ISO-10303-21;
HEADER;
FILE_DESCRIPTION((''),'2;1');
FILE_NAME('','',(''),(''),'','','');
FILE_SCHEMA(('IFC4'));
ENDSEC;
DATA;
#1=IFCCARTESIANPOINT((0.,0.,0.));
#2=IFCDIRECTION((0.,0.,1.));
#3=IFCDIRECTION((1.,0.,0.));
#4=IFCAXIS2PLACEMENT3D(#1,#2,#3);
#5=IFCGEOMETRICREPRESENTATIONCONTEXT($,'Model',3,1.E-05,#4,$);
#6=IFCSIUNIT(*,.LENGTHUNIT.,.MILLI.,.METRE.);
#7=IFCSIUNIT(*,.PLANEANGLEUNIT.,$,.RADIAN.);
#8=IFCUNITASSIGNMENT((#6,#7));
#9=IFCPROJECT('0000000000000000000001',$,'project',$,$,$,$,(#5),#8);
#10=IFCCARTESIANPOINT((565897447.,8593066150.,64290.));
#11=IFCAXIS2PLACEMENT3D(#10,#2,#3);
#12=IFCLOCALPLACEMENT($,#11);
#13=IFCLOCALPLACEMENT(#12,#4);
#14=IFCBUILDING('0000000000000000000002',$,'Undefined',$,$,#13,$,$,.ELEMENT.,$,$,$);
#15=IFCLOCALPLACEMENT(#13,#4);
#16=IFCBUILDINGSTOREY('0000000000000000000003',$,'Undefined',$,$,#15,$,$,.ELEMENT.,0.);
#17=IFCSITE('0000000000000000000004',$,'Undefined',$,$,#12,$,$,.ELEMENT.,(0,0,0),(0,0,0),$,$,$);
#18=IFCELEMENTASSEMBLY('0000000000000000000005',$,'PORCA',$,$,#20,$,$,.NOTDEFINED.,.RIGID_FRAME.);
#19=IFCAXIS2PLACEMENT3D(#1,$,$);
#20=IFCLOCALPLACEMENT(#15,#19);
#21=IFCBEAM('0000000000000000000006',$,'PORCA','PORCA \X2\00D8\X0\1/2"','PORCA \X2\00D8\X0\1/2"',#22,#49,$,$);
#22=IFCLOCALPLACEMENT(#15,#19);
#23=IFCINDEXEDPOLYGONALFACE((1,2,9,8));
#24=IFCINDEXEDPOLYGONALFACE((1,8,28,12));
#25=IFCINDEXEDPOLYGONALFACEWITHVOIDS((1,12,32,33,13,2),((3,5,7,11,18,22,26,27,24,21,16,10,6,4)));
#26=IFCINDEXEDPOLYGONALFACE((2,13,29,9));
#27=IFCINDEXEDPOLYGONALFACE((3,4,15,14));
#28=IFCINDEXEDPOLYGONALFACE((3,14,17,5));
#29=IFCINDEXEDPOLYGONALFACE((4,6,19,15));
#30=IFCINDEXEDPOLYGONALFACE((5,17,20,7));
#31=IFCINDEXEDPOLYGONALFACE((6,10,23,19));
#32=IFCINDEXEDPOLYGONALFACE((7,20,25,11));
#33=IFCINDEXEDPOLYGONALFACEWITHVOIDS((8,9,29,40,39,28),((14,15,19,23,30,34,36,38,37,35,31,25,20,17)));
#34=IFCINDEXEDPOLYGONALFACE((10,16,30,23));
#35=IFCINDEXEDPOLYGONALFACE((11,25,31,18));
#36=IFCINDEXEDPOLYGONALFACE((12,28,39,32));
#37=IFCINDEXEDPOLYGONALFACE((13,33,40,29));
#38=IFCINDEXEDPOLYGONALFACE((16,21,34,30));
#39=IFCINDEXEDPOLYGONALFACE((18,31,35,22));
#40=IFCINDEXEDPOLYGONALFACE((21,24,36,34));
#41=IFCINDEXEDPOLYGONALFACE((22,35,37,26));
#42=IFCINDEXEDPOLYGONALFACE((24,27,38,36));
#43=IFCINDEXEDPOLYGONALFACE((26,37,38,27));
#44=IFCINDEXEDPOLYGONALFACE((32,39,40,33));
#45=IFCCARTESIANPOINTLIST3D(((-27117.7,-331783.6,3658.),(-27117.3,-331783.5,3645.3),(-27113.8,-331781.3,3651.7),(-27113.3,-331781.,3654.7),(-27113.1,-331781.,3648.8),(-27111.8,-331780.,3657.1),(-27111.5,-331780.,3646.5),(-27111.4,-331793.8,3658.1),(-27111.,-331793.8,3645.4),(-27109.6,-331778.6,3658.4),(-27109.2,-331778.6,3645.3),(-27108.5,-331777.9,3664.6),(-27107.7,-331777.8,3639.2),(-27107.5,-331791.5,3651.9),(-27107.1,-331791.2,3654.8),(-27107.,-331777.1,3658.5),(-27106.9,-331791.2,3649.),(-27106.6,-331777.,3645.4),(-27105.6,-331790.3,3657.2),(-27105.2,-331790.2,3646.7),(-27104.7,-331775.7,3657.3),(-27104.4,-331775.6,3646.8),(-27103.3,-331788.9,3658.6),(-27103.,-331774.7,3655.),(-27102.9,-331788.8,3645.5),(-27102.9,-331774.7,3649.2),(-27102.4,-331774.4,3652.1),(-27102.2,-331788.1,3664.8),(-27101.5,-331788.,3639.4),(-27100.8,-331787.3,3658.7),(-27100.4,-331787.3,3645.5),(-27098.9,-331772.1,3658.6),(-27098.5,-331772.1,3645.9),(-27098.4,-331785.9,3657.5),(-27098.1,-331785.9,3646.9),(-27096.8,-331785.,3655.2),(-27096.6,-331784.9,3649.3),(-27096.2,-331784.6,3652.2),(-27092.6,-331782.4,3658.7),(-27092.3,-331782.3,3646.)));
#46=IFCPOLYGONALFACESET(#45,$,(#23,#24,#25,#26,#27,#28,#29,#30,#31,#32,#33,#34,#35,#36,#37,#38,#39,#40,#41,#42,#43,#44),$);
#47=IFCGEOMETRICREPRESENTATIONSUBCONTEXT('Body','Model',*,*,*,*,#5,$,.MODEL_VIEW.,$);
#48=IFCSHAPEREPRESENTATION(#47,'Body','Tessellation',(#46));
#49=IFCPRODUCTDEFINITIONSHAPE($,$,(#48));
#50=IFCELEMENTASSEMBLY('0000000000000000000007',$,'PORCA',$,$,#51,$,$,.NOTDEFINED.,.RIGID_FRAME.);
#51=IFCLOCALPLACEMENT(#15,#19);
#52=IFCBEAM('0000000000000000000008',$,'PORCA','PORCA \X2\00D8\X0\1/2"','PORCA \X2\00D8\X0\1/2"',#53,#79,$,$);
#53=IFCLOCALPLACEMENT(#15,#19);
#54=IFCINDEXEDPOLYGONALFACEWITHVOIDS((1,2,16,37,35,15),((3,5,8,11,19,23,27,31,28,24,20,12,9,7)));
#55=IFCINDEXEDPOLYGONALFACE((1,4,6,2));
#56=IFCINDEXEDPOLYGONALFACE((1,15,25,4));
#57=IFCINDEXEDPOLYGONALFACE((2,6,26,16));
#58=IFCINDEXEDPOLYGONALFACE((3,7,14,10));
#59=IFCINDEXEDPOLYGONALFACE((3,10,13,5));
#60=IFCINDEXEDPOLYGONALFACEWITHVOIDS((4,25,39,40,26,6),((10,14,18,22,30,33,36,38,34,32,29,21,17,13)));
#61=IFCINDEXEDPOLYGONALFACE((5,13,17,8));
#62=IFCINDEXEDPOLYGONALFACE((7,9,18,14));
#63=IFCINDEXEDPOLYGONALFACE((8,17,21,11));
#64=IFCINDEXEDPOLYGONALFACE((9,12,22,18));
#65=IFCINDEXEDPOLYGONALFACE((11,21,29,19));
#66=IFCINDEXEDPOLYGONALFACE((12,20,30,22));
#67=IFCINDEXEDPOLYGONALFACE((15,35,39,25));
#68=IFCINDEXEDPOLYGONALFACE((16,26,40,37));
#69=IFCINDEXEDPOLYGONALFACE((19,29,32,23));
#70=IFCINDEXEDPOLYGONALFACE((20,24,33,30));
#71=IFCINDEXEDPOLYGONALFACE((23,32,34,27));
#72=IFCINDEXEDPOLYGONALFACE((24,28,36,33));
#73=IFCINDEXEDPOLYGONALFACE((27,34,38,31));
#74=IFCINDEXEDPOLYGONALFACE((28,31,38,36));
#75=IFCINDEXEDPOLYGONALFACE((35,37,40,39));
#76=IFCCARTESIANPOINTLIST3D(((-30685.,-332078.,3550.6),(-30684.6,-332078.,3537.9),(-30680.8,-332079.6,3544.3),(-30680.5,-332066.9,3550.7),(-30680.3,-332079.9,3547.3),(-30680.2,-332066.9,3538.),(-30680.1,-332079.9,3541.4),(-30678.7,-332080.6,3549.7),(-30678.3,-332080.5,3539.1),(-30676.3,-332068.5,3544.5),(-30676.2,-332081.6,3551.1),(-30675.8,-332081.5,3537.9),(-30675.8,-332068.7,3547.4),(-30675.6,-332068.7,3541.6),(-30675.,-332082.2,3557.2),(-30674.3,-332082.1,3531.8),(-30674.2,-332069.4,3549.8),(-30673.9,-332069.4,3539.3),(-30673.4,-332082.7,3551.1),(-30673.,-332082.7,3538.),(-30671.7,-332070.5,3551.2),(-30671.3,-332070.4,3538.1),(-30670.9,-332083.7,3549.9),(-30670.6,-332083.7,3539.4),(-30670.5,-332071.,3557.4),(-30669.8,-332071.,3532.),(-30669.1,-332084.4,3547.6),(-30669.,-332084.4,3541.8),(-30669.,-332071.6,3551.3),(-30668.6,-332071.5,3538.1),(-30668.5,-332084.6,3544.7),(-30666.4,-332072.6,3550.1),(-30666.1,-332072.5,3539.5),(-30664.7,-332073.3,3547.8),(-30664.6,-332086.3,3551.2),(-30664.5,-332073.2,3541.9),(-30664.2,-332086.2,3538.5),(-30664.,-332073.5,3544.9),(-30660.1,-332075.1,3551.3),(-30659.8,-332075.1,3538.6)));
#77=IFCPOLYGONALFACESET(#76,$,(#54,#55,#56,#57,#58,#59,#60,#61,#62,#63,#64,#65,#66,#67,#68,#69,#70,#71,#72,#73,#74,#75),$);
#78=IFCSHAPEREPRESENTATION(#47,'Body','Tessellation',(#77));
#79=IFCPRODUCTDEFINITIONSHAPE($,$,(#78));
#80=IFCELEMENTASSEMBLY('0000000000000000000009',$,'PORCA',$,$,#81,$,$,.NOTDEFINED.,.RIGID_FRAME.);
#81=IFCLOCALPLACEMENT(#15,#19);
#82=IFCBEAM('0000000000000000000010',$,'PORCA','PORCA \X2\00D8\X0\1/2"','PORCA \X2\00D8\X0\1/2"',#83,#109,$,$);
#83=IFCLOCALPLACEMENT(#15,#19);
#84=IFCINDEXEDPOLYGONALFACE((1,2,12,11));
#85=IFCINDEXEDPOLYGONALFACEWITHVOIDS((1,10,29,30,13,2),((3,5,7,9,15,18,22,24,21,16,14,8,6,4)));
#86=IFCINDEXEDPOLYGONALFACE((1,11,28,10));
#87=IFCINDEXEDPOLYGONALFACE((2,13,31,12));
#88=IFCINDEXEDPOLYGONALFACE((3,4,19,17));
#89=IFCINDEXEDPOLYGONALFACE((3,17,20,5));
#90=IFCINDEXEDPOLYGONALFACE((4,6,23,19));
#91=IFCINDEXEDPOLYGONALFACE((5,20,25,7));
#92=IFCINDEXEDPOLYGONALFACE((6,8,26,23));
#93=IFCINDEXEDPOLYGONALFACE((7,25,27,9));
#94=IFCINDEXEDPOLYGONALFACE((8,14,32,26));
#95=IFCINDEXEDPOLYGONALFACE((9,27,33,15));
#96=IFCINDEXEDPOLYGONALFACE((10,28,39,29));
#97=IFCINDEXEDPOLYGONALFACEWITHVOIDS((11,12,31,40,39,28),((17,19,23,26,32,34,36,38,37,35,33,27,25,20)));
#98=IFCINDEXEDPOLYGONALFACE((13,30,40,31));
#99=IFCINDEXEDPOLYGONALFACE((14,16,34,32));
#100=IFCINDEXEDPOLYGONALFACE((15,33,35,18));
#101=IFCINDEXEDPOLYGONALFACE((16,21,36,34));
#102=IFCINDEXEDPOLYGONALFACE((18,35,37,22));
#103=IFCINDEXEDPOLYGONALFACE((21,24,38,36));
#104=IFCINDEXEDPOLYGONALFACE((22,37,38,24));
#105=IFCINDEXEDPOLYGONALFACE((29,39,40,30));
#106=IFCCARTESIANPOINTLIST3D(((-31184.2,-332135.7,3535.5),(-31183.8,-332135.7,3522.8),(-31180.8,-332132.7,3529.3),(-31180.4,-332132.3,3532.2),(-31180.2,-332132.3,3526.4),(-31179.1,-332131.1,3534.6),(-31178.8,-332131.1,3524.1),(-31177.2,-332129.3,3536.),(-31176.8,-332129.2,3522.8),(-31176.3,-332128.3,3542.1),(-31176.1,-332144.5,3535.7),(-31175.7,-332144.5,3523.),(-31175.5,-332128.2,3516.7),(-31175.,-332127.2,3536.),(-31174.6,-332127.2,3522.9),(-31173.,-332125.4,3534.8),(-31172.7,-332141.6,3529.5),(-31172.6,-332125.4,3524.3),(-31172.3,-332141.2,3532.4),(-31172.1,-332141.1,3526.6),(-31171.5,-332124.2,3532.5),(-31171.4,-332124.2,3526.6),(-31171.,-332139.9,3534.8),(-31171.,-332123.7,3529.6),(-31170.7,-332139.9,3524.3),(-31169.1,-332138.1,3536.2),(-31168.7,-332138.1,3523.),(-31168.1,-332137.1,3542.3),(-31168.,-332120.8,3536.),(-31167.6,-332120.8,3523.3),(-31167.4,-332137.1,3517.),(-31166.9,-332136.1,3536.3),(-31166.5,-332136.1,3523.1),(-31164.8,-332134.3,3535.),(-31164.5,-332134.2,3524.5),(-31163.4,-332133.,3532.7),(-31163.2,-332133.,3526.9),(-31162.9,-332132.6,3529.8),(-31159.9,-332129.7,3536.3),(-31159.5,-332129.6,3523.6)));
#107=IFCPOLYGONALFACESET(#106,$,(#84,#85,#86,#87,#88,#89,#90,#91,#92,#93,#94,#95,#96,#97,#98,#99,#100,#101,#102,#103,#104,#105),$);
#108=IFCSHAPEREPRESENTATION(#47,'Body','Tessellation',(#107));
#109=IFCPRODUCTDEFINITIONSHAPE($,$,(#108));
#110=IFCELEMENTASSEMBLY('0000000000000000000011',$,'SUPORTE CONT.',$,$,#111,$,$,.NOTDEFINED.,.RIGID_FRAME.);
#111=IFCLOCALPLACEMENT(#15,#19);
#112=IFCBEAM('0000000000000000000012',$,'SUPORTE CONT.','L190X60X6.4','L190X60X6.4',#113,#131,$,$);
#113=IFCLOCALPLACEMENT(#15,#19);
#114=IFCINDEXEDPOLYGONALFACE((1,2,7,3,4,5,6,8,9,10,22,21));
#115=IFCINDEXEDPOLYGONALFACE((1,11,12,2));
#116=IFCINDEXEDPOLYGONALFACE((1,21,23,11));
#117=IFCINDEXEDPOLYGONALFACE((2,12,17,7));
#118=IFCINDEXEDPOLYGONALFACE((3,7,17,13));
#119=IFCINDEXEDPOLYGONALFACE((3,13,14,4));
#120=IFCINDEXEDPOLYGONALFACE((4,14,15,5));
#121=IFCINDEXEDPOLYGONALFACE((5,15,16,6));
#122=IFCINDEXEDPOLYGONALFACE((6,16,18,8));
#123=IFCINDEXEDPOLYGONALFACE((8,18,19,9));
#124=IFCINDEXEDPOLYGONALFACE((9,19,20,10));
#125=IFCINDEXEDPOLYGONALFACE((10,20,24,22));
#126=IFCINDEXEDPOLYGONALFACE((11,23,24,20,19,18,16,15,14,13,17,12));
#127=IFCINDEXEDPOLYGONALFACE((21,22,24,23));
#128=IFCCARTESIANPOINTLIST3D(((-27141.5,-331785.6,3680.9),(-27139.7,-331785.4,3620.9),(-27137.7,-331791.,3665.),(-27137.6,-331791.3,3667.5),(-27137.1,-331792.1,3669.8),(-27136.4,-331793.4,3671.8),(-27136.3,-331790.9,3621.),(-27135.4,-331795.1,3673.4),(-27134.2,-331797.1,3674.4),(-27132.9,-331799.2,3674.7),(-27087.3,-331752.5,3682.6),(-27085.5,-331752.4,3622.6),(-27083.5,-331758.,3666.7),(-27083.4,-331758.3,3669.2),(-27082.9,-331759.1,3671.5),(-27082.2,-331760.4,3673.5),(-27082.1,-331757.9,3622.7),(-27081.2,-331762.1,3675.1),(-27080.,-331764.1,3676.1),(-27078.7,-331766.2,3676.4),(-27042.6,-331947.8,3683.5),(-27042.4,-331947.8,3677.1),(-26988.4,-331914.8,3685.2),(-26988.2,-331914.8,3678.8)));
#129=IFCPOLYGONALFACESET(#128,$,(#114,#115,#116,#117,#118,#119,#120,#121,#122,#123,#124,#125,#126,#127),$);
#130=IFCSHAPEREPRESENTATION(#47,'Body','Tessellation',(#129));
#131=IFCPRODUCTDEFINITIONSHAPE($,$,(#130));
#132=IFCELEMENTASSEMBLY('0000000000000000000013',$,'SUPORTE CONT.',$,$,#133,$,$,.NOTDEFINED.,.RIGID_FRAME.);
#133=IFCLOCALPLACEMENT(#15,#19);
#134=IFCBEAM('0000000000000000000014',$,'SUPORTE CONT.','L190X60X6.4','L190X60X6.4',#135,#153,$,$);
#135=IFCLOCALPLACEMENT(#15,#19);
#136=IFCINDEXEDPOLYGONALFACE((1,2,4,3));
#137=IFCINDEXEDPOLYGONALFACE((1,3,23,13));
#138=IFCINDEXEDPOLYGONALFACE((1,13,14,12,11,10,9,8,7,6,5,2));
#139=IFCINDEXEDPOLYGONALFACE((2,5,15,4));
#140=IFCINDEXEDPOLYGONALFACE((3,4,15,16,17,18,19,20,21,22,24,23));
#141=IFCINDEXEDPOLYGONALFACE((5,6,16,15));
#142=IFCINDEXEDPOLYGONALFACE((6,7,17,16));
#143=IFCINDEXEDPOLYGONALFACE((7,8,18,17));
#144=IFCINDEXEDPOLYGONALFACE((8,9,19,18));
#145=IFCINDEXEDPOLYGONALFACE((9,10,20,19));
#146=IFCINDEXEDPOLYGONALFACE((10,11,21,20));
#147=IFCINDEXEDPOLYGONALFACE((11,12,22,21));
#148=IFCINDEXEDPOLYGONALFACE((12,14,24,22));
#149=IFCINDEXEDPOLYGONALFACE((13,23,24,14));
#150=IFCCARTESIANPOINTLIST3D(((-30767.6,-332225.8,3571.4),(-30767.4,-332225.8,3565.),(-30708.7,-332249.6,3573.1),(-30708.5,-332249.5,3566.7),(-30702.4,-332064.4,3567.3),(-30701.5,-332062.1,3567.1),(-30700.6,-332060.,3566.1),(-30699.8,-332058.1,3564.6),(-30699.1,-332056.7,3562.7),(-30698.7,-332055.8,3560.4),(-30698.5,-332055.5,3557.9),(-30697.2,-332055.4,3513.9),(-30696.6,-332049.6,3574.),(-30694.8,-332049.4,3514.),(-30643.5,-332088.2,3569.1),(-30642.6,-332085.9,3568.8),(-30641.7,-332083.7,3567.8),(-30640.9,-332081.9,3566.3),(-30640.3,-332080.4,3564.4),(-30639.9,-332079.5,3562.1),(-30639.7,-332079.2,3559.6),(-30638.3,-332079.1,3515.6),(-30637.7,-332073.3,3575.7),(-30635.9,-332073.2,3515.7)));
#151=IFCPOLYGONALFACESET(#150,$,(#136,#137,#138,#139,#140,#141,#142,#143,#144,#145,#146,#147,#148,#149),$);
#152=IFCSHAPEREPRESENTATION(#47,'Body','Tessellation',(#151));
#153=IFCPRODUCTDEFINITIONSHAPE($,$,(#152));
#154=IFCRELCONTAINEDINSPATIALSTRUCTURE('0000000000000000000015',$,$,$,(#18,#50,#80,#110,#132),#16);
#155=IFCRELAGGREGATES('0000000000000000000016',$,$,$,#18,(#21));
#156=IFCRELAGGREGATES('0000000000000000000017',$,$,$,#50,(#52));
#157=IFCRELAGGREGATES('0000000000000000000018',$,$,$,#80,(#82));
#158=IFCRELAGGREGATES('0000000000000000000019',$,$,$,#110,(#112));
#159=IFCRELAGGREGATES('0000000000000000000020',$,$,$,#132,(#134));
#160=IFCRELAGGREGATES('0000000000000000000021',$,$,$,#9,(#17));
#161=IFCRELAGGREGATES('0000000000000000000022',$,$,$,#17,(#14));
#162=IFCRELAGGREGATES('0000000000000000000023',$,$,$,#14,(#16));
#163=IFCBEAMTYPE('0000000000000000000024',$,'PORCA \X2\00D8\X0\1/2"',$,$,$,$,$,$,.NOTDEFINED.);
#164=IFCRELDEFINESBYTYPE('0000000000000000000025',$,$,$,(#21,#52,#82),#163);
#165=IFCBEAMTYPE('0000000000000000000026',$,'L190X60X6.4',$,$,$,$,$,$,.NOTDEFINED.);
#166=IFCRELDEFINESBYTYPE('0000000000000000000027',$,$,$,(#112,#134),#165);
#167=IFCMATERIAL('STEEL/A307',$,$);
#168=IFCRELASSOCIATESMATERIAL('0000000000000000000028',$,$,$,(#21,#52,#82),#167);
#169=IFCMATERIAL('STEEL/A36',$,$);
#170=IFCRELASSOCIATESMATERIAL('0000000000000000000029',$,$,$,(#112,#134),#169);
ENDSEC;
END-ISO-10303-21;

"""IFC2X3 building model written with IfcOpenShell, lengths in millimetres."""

from ifc_helpers import new_model, si_unit, frame, origin_with_axes, origin_2d_with_axis, place, context, subcontext, project, spatial, polyline, l_section, outline, extrude, material, type_object, element, aggregate, save


model = new_model("IFC2X3")

# Units and contexts
model_context = context("Model", 3, precision=1e-05, world=origin_with_axes())
body_context = subcontext(model_context, "Body", "Model", "MODEL_VIEW")
ifc_project = project(units=[si_unit("LENGTHUNIT", "METRE", prefix="MILLI"), si_unit("PLANEANGLEUNIT", "RADIAN")], contexts=[model_context])

# Site, building, storey
site_placement = place(None, frame((565897447.0, 8593066150.0, 64290.0), z_axis=(0.0, 0.0, 1.0), x_axis=(1.0, 0.0, 0.0)))
site = spatial("IfcSite", under=ifc_project, at=site_placement, Name="Undefined", CompositionType="ELEMENT", RefLatitude=(0, 0, 0), RefLongitude=(0, 0, 0))
building_placement = place(site_placement, origin_with_axes())
building = spatial("IfcBuilding", under=site, at=building_placement, Name="Undefined", CompositionType="ELEMENT")
storey_placement = place(building_placement, origin_with_axes())
storey = spatial("IfcBuildingStorey", under=building, at=storey_placement, Name="Undefined", CompositionType="ELEMENT", Elevation=0.0)

# Element assemblies, beams
ifc_material_1 = material(Name="STEEL/A36")
ifc_material_2 = material(Name="STEEL/A307")
assembly_1_placement = place(storey_placement, origin_with_axes())
assembly_1 = element("IfcElementAssembly", 1, at=assembly_1_placement, inside=storey, Name="PORCA", AssemblyPlace="NOTDEFINED", PredefinedType="RIGID_FRAME")
beam_type_1 = type_object("IfcBeamType", Name="PORCA Ø1/2\"", PredefinedType="NOTDEFINED")
beam_1_placement = place(assembly_1_placement, frame((-27101.8, -331788.1, 3652.1), z_axis=(-0.853486, -0.520426, -0.026799), x_axis=(-0.520257, 0.853904, -0.013454)))
beam_1 = element("IfcBeam", 2, at=beam_1_placement, type_object=beam_type_1, material=ifc_material_2, Name="PORCA", Description="PORCA Ø1/2\"", ObjectType="PORCA Ø1/2\"", context=body_context, shape_type="SweptSolid", body=[
    extrude(outline(polyline([(-12.7, 0.0), (-6.3, 11.0), (6.3, 11.0), (12.7, 0.0), (6.3, -11.0), (-6.3, -11.0), (-12.7, 0.0)]), holes=[polyline([(5.3, 4.2), (2.9, 6.0), (0.0, 6.7), (-2.9, 6.0), (-5.3, 4.2), (-6.6, 1.5), (-6.6, -1.5), (-5.3, -4.2), (-2.9, -6.0), (0.0, -6.7), (2.9, -6.0), (5.3, -4.2), (6.6, -1.5), (6.6, 1.5), (5.3, 4.2)])]), frame((12.0, 0.0, 0.0), z_axis=(-1.0, 0.0, 0.0), x_axis=(0.0, -1.0, 0.0)), (0.0, 0.0, 1.0), 12.0),
])
aggregate(assembly_1, [beam_1])
assembly_2_placement = place(storey_placement, origin_with_axes())
assembly_2 = element("IfcElementAssembly", 3, at=assembly_2_placement, inside=storey, Name="PORCA", AssemblyPlace="NOTDEFINED", PredefinedType="RIGID_FRAME")
beam_2_placement = place(assembly_2_placement, frame((-30674.6, -332082.1, 3544.5), z_axis=(-0.92709, 0.373879, -0.026799), x_axis=(0.373645, 0.927474, 0.013454)))
beam_2 = element("IfcBeam", 4, at=beam_2_placement, type_object=beam_type_1, material=ifc_material_2, Name="PORCA", Description="PORCA Ø1/2\"", ObjectType="PORCA Ø1/2\"", context=body_context, shape_type="SweptSolid", body=[
    extrude(outline(polyline([(-12.7, 0.0), (-6.3, 11.0), (6.3, 11.0), (12.7, 0.0), (6.3, -11.0), (-6.3, -11.0), (-12.7, 0.0)]), holes=[polyline([(5.3, 4.2), (2.9, 6.0), (0.0, 6.7), (-2.9, 6.0), (-5.3, 4.2), (-6.6, 1.5), (-6.6, -1.5), (-5.3, -4.2), (-2.9, -6.0), (0.0, -6.7), (2.9, -6.0), (5.3, -4.2), (6.6, -1.5), (6.6, 1.5), (5.3, 4.2)])]), frame((12.0, 0.0, 0.0), z_axis=(-1.0, 0.0, 0.0), x_axis=(0.0, -1.0, 0.0)), (0.0, 0.0, 1.0), 12.0),
])
aggregate(assembly_2, [beam_2])
assembly_3_placement = place(storey_placement, origin_with_axes())
assembly_3 = element("IfcElementAssembly", 5, at=assembly_3_placement, inside=storey, Name="PORCA", AssemblyPlace="NOTDEFINED", PredefinedType="RIGID_FRAME")
beam_3_placement = place(assembly_3_placement, frame((-31167.8, -332137.1, 3529.6), z_axis=(-0.736334, -0.676203, -0.02368), x_axis=(-0.675958, 0.736711, -0.018398)))
beam_3 = element("IfcBeam", 6, at=beam_3_placement, type_object=beam_type_1, material=ifc_material_2, Name="PORCA", Description="PORCA Ø1/2\"", ObjectType="PORCA Ø1/2\"", context=body_context, shape_type="SweptSolid", body=[
    extrude(outline(polyline([(-12.7, 0.0), (-6.3, 11.0), (6.3, 11.0), (12.7, 0.0), (6.3, -11.0), (-6.3, -11.0), (-12.7, 0.0)]), holes=[polyline([(5.3, 4.2), (2.9, 6.0), (0.0, 6.7), (-2.9, 6.0), (-5.3, 4.2), (-6.6, 1.5), (-6.6, -1.5), (-5.3, -4.2), (-2.9, -6.0), (0.0, -6.7), (2.9, -6.0), (5.3, -4.2), (6.6, -1.5), (6.6, 1.5), (5.3, 4.2)])]), frame((12.0, 0.0, 0.0), z_axis=(-1.0, 0.0, 0.0), x_axis=(0.0, -1.0, 0.0)), (0.0, 0.0, 1.0), 12.0),
])
aggregate(assembly_3, [beam_3])
assembly_4_placement = place(storey_placement, origin_with_axes())
assembly_4 = element("IfcElementAssembly", 7, at=assembly_4_placement, inside=storey, Name="SUPORTE CONT.", AssemblyPlace="NOTDEFINED", PredefinedType="RIGID_FRAME")
beam_type_2 = type_object("IfcBeamType", Name="L190X60X6.4", PredefinedType="NOTDEFINED")
beam_4_placement = place(assembly_4_placement, frame((-27091.1, -331866.6, 3652.2), z_axis=(0.520257, -0.853904, 0.013454), x_axis=(0.853486, 0.520426, 0.026799)))
beam_4 = element("IfcBeam", 8, at=beam_4_placement, type_object=beam_type_2, material=ifc_material_1, Name="SUPORTE CONT.", Description="L190X60X6.4", ObjectType="L190X60X6.4", context=body_context, shape_type="SweptSolid", body=[
    extrude(l_section(Depth=190.0, Width=60.0, Thickness=6.4, FilletRadius=9.6, at=origin_2d_with_axis()), frame((63.5, 0.0, 0.0), z_axis=(-1.0, 0.0, 0.0), x_axis=(0.0, -1.0, 0.0)), (0.0, 0.0, 1.0), 63.5),
])
assembly_5_placement = place(storey_placement, origin_with_axes())
assembly_5 = element("IfcElementAssembly", 9, at=assembly_5_placement, inside=storey, Name="SUPORTE CONT.", AssemblyPlace="NOTDEFINED", PredefinedType="RIGID_FRAME")
beam_5_placement = place(assembly_5_placement, frame((-30731.2, -332137.6, 3542.7), z_axis=(-0.373645, -0.927474, -0.013454), x_axis=(0.92709, -0.373879, 0.026799)))
beam_5 = element("IfcBeam", 10, at=beam_5_placement, type_object=beam_type_2, material=ifc_material_1, Name="SUPORTE CONT.", Description="L190X60X6.4", ObjectType="L190X60X6.4", context=body_context, shape_type="SweptSolid", body=[
    extrude(l_section(Depth=190.0, Width=60.0, Thickness=6.4, FilletRadius=9.6, at=origin_2d_with_axis()), frame((63.5, 0.0, 0.0), z_axis=(-1.0, 0.0, 0.0), x_axis=(0.0, -1.0, 0.0)), (0.0, 0.0, 1.0), 63.5),
])

aggregate(assembly_4, [beam_4])
aggregate(assembly_5, [beam_5])

save(model, "model.ifc")
